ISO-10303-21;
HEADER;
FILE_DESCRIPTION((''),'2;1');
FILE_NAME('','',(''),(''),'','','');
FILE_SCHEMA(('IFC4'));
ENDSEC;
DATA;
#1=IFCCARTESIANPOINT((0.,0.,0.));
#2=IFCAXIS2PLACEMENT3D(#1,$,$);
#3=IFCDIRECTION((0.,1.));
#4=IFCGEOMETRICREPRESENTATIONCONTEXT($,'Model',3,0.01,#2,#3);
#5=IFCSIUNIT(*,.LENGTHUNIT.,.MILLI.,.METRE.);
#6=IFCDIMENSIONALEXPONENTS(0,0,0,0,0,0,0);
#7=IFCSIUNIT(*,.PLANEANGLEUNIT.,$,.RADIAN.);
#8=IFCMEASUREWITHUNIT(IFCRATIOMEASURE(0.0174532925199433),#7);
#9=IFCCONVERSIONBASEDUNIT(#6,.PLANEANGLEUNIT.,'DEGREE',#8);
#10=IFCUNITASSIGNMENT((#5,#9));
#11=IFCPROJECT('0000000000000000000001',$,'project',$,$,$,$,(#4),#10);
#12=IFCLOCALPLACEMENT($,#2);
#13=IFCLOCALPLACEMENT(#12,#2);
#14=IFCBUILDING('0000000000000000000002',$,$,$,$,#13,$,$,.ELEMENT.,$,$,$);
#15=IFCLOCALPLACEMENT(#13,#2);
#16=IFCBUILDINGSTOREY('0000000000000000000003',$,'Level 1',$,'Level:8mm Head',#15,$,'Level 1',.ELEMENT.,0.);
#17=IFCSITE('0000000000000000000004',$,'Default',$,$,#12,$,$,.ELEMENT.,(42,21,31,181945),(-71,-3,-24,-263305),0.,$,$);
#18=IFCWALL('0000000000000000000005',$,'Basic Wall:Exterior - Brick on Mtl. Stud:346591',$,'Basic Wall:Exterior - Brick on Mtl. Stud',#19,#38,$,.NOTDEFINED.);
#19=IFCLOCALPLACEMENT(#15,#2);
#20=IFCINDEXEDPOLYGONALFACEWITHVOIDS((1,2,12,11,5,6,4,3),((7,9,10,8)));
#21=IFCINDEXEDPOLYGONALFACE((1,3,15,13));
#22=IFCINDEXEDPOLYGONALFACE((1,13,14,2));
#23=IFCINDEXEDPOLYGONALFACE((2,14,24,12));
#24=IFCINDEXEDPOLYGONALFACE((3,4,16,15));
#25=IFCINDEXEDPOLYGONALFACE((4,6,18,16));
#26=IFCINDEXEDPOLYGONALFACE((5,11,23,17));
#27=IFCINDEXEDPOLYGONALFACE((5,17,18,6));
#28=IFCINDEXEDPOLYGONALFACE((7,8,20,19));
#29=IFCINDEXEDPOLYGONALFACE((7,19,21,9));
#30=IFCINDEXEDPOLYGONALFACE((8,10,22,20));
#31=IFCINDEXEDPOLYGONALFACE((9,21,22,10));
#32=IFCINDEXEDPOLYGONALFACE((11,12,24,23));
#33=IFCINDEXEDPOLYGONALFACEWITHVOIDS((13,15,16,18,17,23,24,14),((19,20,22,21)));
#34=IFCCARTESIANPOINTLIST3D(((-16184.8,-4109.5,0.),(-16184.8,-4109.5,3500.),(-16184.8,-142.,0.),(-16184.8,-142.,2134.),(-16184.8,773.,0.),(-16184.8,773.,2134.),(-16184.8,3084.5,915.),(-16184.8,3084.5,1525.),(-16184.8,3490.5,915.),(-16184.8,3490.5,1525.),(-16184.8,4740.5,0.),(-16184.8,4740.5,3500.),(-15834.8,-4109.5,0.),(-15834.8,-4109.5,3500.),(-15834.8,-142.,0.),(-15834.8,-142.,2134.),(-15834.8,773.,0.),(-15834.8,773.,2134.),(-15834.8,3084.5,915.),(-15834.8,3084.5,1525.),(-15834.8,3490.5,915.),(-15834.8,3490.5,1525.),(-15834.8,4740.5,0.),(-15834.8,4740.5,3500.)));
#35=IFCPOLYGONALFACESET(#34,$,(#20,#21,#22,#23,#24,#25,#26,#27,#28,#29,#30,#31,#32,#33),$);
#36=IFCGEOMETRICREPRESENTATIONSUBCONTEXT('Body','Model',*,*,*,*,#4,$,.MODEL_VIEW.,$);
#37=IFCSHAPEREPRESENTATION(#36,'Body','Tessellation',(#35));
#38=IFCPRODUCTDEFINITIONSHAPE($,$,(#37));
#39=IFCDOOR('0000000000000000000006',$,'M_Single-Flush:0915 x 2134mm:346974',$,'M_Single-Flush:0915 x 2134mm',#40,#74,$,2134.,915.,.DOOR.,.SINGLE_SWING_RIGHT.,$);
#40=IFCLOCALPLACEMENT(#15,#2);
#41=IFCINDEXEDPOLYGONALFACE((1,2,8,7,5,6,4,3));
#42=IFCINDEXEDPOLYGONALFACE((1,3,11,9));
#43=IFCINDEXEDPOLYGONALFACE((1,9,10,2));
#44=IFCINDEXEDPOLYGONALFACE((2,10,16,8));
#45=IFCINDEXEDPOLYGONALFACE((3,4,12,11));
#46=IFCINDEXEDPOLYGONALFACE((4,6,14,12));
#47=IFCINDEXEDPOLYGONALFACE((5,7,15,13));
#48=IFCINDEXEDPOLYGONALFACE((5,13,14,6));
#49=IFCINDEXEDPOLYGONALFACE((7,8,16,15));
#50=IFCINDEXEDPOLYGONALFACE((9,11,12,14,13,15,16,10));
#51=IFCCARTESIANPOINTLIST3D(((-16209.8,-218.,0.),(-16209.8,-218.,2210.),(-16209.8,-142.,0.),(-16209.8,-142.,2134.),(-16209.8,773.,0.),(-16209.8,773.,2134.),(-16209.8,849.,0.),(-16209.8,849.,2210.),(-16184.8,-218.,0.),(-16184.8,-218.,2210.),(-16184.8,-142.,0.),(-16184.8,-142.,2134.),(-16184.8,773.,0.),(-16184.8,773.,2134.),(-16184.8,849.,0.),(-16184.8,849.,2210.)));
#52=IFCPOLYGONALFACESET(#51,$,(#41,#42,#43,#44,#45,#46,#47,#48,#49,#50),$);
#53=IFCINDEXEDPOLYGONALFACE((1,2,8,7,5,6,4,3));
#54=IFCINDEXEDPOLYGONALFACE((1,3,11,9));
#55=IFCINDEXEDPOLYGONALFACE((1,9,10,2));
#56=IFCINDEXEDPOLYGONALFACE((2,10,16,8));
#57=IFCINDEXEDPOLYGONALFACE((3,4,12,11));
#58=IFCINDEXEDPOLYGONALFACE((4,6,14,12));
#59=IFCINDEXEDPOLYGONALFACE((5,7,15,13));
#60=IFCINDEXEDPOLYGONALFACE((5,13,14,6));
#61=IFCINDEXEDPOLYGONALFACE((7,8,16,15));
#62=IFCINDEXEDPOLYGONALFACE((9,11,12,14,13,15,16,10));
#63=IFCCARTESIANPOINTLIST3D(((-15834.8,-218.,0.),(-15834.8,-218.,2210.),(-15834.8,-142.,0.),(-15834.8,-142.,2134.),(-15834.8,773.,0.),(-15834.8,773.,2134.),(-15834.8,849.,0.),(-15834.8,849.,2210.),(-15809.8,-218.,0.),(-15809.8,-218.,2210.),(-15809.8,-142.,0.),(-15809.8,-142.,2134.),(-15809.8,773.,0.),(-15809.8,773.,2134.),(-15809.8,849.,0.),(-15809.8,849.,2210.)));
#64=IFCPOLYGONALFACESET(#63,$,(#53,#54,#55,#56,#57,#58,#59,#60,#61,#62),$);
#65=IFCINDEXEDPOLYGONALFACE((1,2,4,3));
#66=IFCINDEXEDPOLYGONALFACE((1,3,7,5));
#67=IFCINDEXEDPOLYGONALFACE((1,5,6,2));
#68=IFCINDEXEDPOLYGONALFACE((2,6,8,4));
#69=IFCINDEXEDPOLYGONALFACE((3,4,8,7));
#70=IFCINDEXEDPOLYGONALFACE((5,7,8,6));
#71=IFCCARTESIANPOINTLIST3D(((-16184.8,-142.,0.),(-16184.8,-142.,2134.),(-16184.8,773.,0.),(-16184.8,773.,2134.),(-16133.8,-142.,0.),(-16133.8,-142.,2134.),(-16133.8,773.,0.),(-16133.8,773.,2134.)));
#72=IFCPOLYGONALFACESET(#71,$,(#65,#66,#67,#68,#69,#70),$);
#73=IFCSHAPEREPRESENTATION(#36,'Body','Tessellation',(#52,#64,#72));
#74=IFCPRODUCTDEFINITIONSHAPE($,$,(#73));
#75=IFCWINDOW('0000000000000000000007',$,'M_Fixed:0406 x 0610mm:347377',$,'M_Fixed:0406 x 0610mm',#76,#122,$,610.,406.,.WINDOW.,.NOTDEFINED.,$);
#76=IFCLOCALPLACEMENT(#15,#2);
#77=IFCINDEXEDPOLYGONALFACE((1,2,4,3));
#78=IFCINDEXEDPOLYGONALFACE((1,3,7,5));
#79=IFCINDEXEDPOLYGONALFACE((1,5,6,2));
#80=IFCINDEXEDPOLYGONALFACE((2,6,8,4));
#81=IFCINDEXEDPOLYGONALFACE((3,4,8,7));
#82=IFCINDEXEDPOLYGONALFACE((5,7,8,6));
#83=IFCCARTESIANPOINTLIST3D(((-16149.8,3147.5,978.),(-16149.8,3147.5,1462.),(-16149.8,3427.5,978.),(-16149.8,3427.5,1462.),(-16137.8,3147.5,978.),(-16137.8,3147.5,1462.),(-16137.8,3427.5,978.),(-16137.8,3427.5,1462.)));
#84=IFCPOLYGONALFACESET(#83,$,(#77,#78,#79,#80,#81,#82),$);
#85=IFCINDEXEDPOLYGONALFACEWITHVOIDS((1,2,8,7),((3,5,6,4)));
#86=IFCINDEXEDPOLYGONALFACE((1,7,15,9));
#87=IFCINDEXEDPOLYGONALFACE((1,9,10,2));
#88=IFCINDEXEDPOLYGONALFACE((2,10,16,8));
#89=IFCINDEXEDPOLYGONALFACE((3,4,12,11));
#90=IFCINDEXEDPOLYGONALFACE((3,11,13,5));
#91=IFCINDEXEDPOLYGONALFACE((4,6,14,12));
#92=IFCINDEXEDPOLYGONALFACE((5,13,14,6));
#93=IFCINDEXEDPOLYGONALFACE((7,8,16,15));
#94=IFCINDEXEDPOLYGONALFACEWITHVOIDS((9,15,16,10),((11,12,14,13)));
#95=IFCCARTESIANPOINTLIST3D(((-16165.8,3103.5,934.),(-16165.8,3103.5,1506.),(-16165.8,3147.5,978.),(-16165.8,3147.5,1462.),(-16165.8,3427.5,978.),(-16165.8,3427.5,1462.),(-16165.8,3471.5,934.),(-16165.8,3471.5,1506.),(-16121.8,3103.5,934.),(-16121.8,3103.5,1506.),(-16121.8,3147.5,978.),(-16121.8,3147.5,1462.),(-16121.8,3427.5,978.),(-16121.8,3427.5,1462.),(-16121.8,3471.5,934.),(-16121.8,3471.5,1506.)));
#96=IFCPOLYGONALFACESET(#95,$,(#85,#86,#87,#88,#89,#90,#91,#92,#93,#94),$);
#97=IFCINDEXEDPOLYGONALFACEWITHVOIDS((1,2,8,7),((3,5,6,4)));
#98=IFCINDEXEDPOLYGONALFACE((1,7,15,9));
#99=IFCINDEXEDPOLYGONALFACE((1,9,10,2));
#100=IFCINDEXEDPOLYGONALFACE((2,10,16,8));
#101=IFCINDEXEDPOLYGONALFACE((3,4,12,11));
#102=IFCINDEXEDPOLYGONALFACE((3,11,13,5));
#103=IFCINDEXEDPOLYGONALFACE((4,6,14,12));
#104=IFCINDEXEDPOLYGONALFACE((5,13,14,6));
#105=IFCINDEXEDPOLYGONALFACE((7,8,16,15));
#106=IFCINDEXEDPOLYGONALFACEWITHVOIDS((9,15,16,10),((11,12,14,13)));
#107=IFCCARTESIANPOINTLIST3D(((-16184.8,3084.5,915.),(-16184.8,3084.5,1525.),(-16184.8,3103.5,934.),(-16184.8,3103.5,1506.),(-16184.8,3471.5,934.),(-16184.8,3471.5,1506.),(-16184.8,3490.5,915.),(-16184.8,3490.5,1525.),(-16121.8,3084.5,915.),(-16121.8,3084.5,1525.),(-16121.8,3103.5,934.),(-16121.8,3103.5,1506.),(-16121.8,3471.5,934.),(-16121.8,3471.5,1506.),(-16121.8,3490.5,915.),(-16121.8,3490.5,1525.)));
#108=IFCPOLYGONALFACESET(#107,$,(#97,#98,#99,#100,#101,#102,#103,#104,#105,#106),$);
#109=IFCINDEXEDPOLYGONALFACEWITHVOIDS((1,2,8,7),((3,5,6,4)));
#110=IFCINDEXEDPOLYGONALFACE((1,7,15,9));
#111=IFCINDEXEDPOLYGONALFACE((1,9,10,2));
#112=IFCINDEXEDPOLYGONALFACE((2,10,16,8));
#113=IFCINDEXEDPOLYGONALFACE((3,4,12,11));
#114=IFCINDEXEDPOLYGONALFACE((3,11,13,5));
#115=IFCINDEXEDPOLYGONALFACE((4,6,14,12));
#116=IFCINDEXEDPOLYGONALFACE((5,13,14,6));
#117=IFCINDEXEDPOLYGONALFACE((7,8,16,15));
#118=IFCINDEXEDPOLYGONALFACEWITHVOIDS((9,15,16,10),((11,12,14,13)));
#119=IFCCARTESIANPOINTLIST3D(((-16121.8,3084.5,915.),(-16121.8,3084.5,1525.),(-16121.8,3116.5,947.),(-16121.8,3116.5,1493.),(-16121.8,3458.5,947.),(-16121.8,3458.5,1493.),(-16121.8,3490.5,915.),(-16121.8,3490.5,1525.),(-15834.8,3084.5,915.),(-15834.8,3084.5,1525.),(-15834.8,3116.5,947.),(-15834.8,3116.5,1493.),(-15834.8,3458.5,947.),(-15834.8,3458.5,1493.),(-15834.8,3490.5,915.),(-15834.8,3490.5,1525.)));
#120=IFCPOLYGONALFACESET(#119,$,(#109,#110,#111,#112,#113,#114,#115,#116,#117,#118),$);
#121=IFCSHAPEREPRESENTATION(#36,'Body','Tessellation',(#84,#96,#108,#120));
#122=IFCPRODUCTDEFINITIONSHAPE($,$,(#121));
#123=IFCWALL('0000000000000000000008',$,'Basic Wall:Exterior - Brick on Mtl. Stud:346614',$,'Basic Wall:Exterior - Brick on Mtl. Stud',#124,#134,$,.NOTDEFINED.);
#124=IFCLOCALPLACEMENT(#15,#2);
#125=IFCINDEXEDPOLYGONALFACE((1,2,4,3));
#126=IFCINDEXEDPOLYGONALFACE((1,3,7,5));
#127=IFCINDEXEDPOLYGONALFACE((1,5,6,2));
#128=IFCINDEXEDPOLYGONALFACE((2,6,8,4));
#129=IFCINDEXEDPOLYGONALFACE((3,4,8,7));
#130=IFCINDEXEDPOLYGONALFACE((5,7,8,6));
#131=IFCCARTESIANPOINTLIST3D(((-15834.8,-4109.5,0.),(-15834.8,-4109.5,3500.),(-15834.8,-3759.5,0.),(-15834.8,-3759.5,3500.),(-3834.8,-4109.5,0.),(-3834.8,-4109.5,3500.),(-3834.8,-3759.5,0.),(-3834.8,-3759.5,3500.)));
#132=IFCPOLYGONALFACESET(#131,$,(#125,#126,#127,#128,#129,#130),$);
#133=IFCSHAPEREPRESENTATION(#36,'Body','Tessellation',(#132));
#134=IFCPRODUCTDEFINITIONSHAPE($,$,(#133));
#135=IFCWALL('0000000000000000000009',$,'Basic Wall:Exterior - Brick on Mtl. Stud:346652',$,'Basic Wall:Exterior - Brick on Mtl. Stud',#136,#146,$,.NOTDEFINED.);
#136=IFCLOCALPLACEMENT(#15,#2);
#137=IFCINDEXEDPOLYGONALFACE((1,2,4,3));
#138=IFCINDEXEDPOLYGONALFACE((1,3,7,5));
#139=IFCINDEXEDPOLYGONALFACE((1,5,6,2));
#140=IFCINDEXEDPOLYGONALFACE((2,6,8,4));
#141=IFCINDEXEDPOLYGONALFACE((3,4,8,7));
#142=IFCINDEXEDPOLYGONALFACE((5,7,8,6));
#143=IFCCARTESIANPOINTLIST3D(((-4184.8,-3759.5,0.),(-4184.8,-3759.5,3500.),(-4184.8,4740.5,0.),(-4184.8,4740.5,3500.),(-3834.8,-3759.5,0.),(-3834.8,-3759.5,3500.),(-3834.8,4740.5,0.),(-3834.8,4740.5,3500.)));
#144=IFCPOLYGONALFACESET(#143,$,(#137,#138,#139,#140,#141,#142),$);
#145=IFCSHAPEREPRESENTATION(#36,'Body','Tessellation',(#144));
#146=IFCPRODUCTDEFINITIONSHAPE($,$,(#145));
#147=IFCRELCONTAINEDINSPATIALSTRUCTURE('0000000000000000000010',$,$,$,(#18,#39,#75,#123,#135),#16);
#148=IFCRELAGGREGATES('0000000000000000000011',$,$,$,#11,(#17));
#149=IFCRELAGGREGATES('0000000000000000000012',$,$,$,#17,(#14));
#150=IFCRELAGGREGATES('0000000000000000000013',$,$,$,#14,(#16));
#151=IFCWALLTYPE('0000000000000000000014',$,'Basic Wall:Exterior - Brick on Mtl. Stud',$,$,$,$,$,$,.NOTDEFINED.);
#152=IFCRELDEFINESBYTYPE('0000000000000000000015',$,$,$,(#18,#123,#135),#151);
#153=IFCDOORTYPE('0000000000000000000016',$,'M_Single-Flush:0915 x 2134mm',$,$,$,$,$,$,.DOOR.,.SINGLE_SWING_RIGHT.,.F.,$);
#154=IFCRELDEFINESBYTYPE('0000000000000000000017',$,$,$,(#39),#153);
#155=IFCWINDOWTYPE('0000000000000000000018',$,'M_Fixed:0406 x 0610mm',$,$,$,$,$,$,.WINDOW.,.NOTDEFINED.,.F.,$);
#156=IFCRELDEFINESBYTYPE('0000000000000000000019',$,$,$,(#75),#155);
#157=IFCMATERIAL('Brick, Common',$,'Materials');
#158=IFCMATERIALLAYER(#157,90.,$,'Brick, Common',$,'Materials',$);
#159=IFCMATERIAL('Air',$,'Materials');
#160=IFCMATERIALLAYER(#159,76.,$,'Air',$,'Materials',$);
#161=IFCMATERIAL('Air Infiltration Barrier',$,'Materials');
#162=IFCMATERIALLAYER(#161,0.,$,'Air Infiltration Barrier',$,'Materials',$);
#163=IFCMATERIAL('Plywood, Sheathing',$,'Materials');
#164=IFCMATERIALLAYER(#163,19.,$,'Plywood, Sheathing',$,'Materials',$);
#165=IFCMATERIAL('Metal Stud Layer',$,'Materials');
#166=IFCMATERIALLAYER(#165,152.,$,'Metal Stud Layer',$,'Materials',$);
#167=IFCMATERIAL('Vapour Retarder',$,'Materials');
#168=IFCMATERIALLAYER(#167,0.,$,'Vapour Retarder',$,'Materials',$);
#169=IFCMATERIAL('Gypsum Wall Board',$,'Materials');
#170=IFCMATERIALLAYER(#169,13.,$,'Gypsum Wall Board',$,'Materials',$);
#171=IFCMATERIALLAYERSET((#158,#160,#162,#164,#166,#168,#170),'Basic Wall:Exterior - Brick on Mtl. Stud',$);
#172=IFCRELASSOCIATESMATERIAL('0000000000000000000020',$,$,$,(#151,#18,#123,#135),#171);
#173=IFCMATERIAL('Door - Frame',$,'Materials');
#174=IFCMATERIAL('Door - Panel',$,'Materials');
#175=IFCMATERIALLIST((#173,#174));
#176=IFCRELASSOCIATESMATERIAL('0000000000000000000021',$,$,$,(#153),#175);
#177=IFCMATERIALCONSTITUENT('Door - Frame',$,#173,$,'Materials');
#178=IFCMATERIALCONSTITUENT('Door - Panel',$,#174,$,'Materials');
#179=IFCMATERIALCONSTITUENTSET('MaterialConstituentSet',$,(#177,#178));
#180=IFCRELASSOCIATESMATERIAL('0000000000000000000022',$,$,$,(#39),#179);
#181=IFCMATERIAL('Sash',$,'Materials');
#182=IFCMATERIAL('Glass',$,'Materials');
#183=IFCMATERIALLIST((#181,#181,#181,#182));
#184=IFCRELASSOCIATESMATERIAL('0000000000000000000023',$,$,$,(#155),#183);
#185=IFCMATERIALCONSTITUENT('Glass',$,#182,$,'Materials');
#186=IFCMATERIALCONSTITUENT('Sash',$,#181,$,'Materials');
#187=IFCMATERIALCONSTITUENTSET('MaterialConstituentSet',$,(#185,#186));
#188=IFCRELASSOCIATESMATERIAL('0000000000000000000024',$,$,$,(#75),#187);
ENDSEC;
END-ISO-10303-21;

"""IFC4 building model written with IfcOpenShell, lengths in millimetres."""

from ifc_helpers import new_model, entity, si_unit, converted_unit, direction, frame, frame_2d, origin, place, context, subcontext, project, spatial, polyline, rectangle, outline, extrude, source, transform, mapped, material, material_list, layer, layer_set, layer_usage, constituent, constituent_set, type_object, type_shapes, element, fill, save


model = new_model("IFC4")

# Units and contexts
model_context = context("Model", 3, precision=0.01, world=origin(), true_north=direction((0.0, 1.0)))
body_context = subcontext(model_context, "Body", "Model", "MODEL_VIEW")
ifc_project = project(units=[si_unit("LENGTHUNIT", "METRE", prefix="MILLI"), converted_unit("PLANEANGLEUNIT", "DEGREE", entity("IfcRatioMeasure", 0.0174532925199433), si_unit("PLANEANGLEUNIT", "RADIAN"), dimensions=[0, 0, 0, 0, 0, 0, 0])], contexts=[model_context])

# Site, building, storey
site_placement = place(None, origin())
site = spatial("IfcSite", under=ifc_project, at=site_placement, Name="Default", CompositionType="ELEMENT", RefLatitude=(42, 21, 31, 181945), RefLongitude=(-71, -3, -24, -263305), RefElevation=0.0)
building_placement = place(site_placement, origin())
building = spatial("IfcBuilding", under=site, at=building_placement, CompositionType="ELEMENT")
storey_placement = place(building_placement, origin())
storey = spatial("IfcBuildingStorey", under=building, at=storey_placement, Name="Level 1", ObjectType="Level:8mm Head", LongName="Level 1", CompositionType="ELEMENT", Elevation=0.0)

# Wall, openings, door, window
ifc_material_1 = material(Name="Brick, Common", Category="Materials")
ifc_layer_1 = layer(ifc_material_1, 90.0, Name="Brick, Common", Category="Materials")
ifc_material_2 = material(Name="Air", Category="Materials")
ifc_layer_2 = layer(ifc_material_2, 76.0, Name="Air", Category="Materials")
ifc_material_3 = material(Name="Air Infiltration Barrier", Category="Materials")
ifc_layer_3 = layer(ifc_material_3, 0.0, Name="Air Infiltration Barrier", Category="Materials")
ifc_material_4 = material(Name="Plywood, Sheathing", Category="Materials")
ifc_layer_4 = layer(ifc_material_4, 19.0, Name="Plywood, Sheathing", Category="Materials")
ifc_material_5 = material(Name="Metal Stud Layer", Category="Materials")
ifc_layer_5 = layer(ifc_material_5, 152.0, Name="Metal Stud Layer", Category="Materials")
ifc_material_6 = material(Name="Vapour Retarder", Category="Materials")
ifc_layer_6 = layer(ifc_material_6, 0.0, Name="Vapour Retarder", Category="Materials")
ifc_material_7 = material(Name="Gypsum Wall Board", Category="Materials")
ifc_layer_7 = layer(ifc_material_7, 13.0, Name="Gypsum Wall Board", Category="Materials")
ifc_layer_set_1 = layer_set([ifc_layer_1, ifc_layer_2, ifc_layer_3, ifc_layer_4, ifc_layer_5, ifc_layer_6, ifc_layer_7], Name="Basic Wall:Exterior - Brick on Mtl. Stud")
ifc_layer_usage_1 = layer_usage(ifc_layer_set_1, "AXIS2", "NEGATIVE", 175.0)
wall_type_1 = type_object("IfcWallType", Name="Basic Wall:Exterior - Brick on Mtl. Stud", PredefinedType="NOTDEFINED", material=ifc_layer_set_1)
wall_1_placement = place(storey_placement, frame((-16009.8, 4740.5, 0.0), z_axis=(0.0, 0.0, 1.0), x_axis=(0.0, -1.0, 0.0)))
wall_1 = element("IfcWall", 1, at=wall_1_placement, inside=storey, type_object=wall_type_1, material=ifc_layer_usage_1, Name="Basic Wall:Exterior - Brick on Mtl. Stud:346591", ObjectType="Basic Wall:Exterior - Brick on Mtl. Stud", PredefinedType="NOTDEFINED", context=body_context, shape_type="SweptSolid", body=[
    extrude(rectangle(XDim=8850.0, YDim=350.0, at=frame_2d((4425.0, 0.0), x_axis=(-1.0, 0.0))), origin(), (0.0, 0.0, 1.0), 3500.0),
])
opening_1_placement = place(wall_1_placement, frame((4882.5, 175.0, 0.0)))
opening_1 = element("IfcOpeningElement", 2, at=opening_1_placement, cuts=wall_1, ObjectType="Opening", PredefinedType="OPENING", context=body_context, shape_type="SweptSolid", body=[
    extrude(rectangle(XDim=915.0, YDim=2134.0, at=frame_2d((1067.0, 457.5), x_axis=(0.0, 1.0))), frame((0.0, 0.0, 0.0), z_axis=(0.0, -1.0, 0.0), x_axis=(0.0, 0.0, 1.0)), (0.0, 0.0, 1.0), 350.0),
])
opening_2_placement = place(wall_1_placement, frame((1656.0, 175.0, 915.0)))
opening_2 = element("IfcOpeningElement", 3, at=opening_2_placement, cuts=wall_1, ObjectType="Opening", PredefinedType="OPENING", context=body_context, shape_type="SweptSolid", body=[
    extrude(rectangle(XDim=610.0, YDim=406.0, at=frame_2d((305.0, 203.0), x_axis=(1.0, 0.0))), frame((0.0, 0.0, 0.0), z_axis=(0.0, -1.0, 0.0), x_axis=(0.0, 0.0, 1.0)), (0.0, 0.0, 1.0), 350.0),
])
ifc_material_8 = material(Name="Door - Frame", Category="Materials")
ifc_constituent_1 = constituent(ifc_material_8, Name="Door - Frame", Category="Materials")
ifc_material_9 = material(Name="Door - Panel", Category="Materials")
ifc_constituent_2 = constituent(ifc_material_9, Name="Door - Panel", Category="Materials")
ifc_constituent_set_1 = constituent_set(constituents=[ifc_constituent_1, ifc_constituent_2], Name="MaterialConstituentSet")
ifc_material_list_1 = material_list([ifc_material_8, ifc_material_9])
door_type_1 = type_object("IfcDoorType", Name="M_Single-Flush:0915 x 2134mm", OperationType="SINGLE_SWING_RIGHT", ParameterTakesPrecedence=False, PredefinedType="DOOR", material=ifc_material_list_1)
shared_shape_1 = source(origin(), body_context, "Body", "SweptSolid", [
    extrude(outline(polyline([(-533.5, -1124.0), (533.5, -1124.0), (533.5, 1086.0), (457.5, 1086.0), (457.5, -1048.0), (-457.5, -1048.0), (-457.5, 1086.0), (-533.5, 1086.0), (-533.5, -1124.0)])), frame((457.5, 350.0, 1086.0), z_axis=(0.0, 1.0, 0.0), x_axis=(1.0, 0.0, 0.0)), (0.0, 0.0, 1.0), 25.0),
    extrude(outline(polyline([(-1124.0, -533.5), (1086.0, -533.5), (1086.0, -457.5), (-1048.0, -457.5), (-1048.0, 457.5), (1086.0, 457.5), (1086.0, 533.5), (-1124.0, 533.5), (-1124.0, -533.5)])), frame((457.5, -25.0, 1086.0), z_axis=(0.0, 1.0, 0.0), x_axis=(0.0, 0.0, -1.0)), (0.0, 0.0, 1.0), 25.0),
    extrude(rectangle(XDim=51.0, YDim=915.0, at=frame_2d((0.0, 0.0), x_axis=(1.0, 0.0))), frame((457.5, 324.5, 0.0), z_axis=(0.0, 0.0, 1.0), x_axis=(0.0, 1.0, 0.0)), (0.0, 0.0, 1.0), 2134.0),
])
type_shapes(door_type_1, [shared_shape_1])
door_1_placement = place(opening_1_placement, frame((0.0, 0.0, 0.0), z_axis=(0.0, 0.0, 1.0), x_axis=(-1.0, 0.0, 0.0)))
door_1 = element("IfcDoor", 4, at=door_1_placement, inside=storey, type_object=door_type_1, material=ifc_constituent_set_1, Name="M_Single-Flush:0915 x 2134mm:346974", ObjectType="M_Single-Flush:0915 x 2134mm", OperationType="SINGLE_SWING_RIGHT", OverallHeight=2134.0, OverallWidth=915.0, PredefinedType="DOOR", context=body_context, shape_type="MappedRepresentation", body=[
    mapped(shared_shape_1, transform((0.0, 0.0, 0.0), scale=1.0)),
])
fill(opening_1, door_1)
ifc_material_10 = material(Name="Glass", Category="Materials")
ifc_constituent_3 = constituent(ifc_material_10, Name="Glass", Category="Materials")
ifc_material_11 = material(Name="Sash", Category="Materials")
ifc_constituent_4 = constituent(ifc_material_11, Name="Sash", Category="Materials")
ifc_constituent_set_2 = constituent_set(constituents=[ifc_constituent_3, ifc_constituent_4], Name="MaterialConstituentSet")
ifc_material_list_2 = material_list([ifc_material_11, ifc_material_11, ifc_material_11, ifc_material_10])
window_type_1 = type_object("IfcWindowType", Name="M_Fixed:0406 x 0610mm", ParameterTakesPrecedence=False, PartitioningType="NOTDEFINED", PredefinedType="WINDOW", material=ifc_material_list_2)
shared_shape_2 = source(origin(), body_context, "Body", "SweptSolid", [
    extrude(rectangle(XDim=12.0, YDim=280.0, at=frame_2d((0.0, 0.0), x_axis=(1.0, 0.0))), frame((203.0, 309.0, 63.0), z_axis=(0.0, 0.0, 1.0), x_axis=(0.0, -1.0, 0.0)), (0.0, 0.0, 1.0), 484.0),
    extrude(outline(polyline([(-184.0, -286.0), (184.0, -286.0), (184.0, 286.0), (-184.0, 286.0), (-184.0, -286.0)]), holes=[polyline([(-140.0, -242.0), (-140.0, 242.0), (140.0, 242.0), (140.0, -242.0), (-140.0, -242.0)])]), frame((203.0, 287.0, 305.0), z_axis=(0.0, 1.0, 0.0), x_axis=(1.0, 0.0, 0.0)), (0.0, 0.0, 1.0), 44.0),
    extrude(outline(polyline([(-203.0, -305.0), (203.0, -305.0), (203.0, 305.0), (-203.0, 305.0), (-203.0, -305.0)]), holes=[polyline([(-184.0, -286.0), (-184.0, 286.0), (184.0, 286.0), (184.0, -286.0), (-184.0, -286.0)])]), frame((203.0, 287.0, 305.0), z_axis=(0.0, 1.0, 0.0), x_axis=(1.0, 0.0, 0.0)), (0.0, 0.0, 1.0), 63.0),
    extrude(outline(polyline([(-203.0, -305.0), (203.0, -305.0), (203.0, 305.0), (-203.0, 305.0), (-203.0, -305.0)]), holes=[polyline([(-171.0, -273.0), (-171.0, 273.0), (171.0, 273.0), (171.0, -273.0), (-171.0, -273.0)])]), frame((203.0, 0.0, 305.0), z_axis=(0.0, 1.0, 0.0), x_axis=(1.0, 0.0, 0.0)), (0.0, 0.0, 1.0), 287.0),
])
type_shapes(window_type_1, [shared_shape_2])
window_1_placement = place(opening_2_placement, frame((0.0, 0.0, 0.0), z_axis=(0.0, 0.0, 1.0), x_axis=(-1.0, 0.0, 0.0)))
window_1 = element("IfcWindow", 5, at=window_1_placement, inside=storey, type_object=window_type_1, material=ifc_constituent_set_2, Name="M_Fixed:0406 x 0610mm:347377", ObjectType="M_Fixed:0406 x 0610mm", OverallHeight=610.0, OverallWidth=406.0, PartitioningType="NOTDEFINED", PredefinedType="WINDOW", context=body_context, shape_type="MappedRepresentation", body=[
    mapped(shared_shape_2, transform((0.0, 0.0, 0.0), scale=1.0)),
])
fill(opening_2, window_1)

# Walls
ifc_layer_usage_2 = layer_usage(ifc_layer_set_1, "AXIS2", "NEGATIVE", 175.0)
wall_2_placement = place(storey_placement, frame((-15834.8, -3934.5, 0.0)))
element("IfcWall", 6, at=wall_2_placement, inside=storey, type_object=wall_type_1, material=ifc_layer_usage_2, Name="Basic Wall:Exterior - Brick on Mtl. Stud:346614", ObjectType="Basic Wall:Exterior - Brick on Mtl. Stud", PredefinedType="NOTDEFINED", context=body_context, shape_type="SweptSolid", body=[
    extrude(rectangle(XDim=12000.0, YDim=350.0, at=frame_2d((6000.0, 0.0), x_axis=(-1.0, 0.0))), origin(), (0.0, 0.0, 1.0), 3500.0),
])
ifc_layer_usage_3 = layer_usage(ifc_layer_set_1, "AXIS2", "NEGATIVE", 175.0)
wall_3_placement = place(storey_placement, frame((-4009.8, -3759.5, 0.0), z_axis=(0.0, 0.0, 1.0), x_axis=(0.0, 1.0, 0.0)))
element("IfcWall", 7, at=wall_3_placement, inside=storey, type_object=wall_type_1, material=ifc_layer_usage_3, Name="Basic Wall:Exterior - Brick on Mtl. Stud:346652", ObjectType="Basic Wall:Exterior - Brick on Mtl. Stud", PredefinedType="NOTDEFINED", context=body_context, shape_type="SweptSolid", body=[
    extrude(rectangle(XDim=8500.0, YDim=350.0, at=frame_2d((4250.0, 0.0), x_axis=(-1.0, 0.0))), origin(), (0.0, 0.0, 1.0), 3500.0),
])

save(model, "model.ifc")
